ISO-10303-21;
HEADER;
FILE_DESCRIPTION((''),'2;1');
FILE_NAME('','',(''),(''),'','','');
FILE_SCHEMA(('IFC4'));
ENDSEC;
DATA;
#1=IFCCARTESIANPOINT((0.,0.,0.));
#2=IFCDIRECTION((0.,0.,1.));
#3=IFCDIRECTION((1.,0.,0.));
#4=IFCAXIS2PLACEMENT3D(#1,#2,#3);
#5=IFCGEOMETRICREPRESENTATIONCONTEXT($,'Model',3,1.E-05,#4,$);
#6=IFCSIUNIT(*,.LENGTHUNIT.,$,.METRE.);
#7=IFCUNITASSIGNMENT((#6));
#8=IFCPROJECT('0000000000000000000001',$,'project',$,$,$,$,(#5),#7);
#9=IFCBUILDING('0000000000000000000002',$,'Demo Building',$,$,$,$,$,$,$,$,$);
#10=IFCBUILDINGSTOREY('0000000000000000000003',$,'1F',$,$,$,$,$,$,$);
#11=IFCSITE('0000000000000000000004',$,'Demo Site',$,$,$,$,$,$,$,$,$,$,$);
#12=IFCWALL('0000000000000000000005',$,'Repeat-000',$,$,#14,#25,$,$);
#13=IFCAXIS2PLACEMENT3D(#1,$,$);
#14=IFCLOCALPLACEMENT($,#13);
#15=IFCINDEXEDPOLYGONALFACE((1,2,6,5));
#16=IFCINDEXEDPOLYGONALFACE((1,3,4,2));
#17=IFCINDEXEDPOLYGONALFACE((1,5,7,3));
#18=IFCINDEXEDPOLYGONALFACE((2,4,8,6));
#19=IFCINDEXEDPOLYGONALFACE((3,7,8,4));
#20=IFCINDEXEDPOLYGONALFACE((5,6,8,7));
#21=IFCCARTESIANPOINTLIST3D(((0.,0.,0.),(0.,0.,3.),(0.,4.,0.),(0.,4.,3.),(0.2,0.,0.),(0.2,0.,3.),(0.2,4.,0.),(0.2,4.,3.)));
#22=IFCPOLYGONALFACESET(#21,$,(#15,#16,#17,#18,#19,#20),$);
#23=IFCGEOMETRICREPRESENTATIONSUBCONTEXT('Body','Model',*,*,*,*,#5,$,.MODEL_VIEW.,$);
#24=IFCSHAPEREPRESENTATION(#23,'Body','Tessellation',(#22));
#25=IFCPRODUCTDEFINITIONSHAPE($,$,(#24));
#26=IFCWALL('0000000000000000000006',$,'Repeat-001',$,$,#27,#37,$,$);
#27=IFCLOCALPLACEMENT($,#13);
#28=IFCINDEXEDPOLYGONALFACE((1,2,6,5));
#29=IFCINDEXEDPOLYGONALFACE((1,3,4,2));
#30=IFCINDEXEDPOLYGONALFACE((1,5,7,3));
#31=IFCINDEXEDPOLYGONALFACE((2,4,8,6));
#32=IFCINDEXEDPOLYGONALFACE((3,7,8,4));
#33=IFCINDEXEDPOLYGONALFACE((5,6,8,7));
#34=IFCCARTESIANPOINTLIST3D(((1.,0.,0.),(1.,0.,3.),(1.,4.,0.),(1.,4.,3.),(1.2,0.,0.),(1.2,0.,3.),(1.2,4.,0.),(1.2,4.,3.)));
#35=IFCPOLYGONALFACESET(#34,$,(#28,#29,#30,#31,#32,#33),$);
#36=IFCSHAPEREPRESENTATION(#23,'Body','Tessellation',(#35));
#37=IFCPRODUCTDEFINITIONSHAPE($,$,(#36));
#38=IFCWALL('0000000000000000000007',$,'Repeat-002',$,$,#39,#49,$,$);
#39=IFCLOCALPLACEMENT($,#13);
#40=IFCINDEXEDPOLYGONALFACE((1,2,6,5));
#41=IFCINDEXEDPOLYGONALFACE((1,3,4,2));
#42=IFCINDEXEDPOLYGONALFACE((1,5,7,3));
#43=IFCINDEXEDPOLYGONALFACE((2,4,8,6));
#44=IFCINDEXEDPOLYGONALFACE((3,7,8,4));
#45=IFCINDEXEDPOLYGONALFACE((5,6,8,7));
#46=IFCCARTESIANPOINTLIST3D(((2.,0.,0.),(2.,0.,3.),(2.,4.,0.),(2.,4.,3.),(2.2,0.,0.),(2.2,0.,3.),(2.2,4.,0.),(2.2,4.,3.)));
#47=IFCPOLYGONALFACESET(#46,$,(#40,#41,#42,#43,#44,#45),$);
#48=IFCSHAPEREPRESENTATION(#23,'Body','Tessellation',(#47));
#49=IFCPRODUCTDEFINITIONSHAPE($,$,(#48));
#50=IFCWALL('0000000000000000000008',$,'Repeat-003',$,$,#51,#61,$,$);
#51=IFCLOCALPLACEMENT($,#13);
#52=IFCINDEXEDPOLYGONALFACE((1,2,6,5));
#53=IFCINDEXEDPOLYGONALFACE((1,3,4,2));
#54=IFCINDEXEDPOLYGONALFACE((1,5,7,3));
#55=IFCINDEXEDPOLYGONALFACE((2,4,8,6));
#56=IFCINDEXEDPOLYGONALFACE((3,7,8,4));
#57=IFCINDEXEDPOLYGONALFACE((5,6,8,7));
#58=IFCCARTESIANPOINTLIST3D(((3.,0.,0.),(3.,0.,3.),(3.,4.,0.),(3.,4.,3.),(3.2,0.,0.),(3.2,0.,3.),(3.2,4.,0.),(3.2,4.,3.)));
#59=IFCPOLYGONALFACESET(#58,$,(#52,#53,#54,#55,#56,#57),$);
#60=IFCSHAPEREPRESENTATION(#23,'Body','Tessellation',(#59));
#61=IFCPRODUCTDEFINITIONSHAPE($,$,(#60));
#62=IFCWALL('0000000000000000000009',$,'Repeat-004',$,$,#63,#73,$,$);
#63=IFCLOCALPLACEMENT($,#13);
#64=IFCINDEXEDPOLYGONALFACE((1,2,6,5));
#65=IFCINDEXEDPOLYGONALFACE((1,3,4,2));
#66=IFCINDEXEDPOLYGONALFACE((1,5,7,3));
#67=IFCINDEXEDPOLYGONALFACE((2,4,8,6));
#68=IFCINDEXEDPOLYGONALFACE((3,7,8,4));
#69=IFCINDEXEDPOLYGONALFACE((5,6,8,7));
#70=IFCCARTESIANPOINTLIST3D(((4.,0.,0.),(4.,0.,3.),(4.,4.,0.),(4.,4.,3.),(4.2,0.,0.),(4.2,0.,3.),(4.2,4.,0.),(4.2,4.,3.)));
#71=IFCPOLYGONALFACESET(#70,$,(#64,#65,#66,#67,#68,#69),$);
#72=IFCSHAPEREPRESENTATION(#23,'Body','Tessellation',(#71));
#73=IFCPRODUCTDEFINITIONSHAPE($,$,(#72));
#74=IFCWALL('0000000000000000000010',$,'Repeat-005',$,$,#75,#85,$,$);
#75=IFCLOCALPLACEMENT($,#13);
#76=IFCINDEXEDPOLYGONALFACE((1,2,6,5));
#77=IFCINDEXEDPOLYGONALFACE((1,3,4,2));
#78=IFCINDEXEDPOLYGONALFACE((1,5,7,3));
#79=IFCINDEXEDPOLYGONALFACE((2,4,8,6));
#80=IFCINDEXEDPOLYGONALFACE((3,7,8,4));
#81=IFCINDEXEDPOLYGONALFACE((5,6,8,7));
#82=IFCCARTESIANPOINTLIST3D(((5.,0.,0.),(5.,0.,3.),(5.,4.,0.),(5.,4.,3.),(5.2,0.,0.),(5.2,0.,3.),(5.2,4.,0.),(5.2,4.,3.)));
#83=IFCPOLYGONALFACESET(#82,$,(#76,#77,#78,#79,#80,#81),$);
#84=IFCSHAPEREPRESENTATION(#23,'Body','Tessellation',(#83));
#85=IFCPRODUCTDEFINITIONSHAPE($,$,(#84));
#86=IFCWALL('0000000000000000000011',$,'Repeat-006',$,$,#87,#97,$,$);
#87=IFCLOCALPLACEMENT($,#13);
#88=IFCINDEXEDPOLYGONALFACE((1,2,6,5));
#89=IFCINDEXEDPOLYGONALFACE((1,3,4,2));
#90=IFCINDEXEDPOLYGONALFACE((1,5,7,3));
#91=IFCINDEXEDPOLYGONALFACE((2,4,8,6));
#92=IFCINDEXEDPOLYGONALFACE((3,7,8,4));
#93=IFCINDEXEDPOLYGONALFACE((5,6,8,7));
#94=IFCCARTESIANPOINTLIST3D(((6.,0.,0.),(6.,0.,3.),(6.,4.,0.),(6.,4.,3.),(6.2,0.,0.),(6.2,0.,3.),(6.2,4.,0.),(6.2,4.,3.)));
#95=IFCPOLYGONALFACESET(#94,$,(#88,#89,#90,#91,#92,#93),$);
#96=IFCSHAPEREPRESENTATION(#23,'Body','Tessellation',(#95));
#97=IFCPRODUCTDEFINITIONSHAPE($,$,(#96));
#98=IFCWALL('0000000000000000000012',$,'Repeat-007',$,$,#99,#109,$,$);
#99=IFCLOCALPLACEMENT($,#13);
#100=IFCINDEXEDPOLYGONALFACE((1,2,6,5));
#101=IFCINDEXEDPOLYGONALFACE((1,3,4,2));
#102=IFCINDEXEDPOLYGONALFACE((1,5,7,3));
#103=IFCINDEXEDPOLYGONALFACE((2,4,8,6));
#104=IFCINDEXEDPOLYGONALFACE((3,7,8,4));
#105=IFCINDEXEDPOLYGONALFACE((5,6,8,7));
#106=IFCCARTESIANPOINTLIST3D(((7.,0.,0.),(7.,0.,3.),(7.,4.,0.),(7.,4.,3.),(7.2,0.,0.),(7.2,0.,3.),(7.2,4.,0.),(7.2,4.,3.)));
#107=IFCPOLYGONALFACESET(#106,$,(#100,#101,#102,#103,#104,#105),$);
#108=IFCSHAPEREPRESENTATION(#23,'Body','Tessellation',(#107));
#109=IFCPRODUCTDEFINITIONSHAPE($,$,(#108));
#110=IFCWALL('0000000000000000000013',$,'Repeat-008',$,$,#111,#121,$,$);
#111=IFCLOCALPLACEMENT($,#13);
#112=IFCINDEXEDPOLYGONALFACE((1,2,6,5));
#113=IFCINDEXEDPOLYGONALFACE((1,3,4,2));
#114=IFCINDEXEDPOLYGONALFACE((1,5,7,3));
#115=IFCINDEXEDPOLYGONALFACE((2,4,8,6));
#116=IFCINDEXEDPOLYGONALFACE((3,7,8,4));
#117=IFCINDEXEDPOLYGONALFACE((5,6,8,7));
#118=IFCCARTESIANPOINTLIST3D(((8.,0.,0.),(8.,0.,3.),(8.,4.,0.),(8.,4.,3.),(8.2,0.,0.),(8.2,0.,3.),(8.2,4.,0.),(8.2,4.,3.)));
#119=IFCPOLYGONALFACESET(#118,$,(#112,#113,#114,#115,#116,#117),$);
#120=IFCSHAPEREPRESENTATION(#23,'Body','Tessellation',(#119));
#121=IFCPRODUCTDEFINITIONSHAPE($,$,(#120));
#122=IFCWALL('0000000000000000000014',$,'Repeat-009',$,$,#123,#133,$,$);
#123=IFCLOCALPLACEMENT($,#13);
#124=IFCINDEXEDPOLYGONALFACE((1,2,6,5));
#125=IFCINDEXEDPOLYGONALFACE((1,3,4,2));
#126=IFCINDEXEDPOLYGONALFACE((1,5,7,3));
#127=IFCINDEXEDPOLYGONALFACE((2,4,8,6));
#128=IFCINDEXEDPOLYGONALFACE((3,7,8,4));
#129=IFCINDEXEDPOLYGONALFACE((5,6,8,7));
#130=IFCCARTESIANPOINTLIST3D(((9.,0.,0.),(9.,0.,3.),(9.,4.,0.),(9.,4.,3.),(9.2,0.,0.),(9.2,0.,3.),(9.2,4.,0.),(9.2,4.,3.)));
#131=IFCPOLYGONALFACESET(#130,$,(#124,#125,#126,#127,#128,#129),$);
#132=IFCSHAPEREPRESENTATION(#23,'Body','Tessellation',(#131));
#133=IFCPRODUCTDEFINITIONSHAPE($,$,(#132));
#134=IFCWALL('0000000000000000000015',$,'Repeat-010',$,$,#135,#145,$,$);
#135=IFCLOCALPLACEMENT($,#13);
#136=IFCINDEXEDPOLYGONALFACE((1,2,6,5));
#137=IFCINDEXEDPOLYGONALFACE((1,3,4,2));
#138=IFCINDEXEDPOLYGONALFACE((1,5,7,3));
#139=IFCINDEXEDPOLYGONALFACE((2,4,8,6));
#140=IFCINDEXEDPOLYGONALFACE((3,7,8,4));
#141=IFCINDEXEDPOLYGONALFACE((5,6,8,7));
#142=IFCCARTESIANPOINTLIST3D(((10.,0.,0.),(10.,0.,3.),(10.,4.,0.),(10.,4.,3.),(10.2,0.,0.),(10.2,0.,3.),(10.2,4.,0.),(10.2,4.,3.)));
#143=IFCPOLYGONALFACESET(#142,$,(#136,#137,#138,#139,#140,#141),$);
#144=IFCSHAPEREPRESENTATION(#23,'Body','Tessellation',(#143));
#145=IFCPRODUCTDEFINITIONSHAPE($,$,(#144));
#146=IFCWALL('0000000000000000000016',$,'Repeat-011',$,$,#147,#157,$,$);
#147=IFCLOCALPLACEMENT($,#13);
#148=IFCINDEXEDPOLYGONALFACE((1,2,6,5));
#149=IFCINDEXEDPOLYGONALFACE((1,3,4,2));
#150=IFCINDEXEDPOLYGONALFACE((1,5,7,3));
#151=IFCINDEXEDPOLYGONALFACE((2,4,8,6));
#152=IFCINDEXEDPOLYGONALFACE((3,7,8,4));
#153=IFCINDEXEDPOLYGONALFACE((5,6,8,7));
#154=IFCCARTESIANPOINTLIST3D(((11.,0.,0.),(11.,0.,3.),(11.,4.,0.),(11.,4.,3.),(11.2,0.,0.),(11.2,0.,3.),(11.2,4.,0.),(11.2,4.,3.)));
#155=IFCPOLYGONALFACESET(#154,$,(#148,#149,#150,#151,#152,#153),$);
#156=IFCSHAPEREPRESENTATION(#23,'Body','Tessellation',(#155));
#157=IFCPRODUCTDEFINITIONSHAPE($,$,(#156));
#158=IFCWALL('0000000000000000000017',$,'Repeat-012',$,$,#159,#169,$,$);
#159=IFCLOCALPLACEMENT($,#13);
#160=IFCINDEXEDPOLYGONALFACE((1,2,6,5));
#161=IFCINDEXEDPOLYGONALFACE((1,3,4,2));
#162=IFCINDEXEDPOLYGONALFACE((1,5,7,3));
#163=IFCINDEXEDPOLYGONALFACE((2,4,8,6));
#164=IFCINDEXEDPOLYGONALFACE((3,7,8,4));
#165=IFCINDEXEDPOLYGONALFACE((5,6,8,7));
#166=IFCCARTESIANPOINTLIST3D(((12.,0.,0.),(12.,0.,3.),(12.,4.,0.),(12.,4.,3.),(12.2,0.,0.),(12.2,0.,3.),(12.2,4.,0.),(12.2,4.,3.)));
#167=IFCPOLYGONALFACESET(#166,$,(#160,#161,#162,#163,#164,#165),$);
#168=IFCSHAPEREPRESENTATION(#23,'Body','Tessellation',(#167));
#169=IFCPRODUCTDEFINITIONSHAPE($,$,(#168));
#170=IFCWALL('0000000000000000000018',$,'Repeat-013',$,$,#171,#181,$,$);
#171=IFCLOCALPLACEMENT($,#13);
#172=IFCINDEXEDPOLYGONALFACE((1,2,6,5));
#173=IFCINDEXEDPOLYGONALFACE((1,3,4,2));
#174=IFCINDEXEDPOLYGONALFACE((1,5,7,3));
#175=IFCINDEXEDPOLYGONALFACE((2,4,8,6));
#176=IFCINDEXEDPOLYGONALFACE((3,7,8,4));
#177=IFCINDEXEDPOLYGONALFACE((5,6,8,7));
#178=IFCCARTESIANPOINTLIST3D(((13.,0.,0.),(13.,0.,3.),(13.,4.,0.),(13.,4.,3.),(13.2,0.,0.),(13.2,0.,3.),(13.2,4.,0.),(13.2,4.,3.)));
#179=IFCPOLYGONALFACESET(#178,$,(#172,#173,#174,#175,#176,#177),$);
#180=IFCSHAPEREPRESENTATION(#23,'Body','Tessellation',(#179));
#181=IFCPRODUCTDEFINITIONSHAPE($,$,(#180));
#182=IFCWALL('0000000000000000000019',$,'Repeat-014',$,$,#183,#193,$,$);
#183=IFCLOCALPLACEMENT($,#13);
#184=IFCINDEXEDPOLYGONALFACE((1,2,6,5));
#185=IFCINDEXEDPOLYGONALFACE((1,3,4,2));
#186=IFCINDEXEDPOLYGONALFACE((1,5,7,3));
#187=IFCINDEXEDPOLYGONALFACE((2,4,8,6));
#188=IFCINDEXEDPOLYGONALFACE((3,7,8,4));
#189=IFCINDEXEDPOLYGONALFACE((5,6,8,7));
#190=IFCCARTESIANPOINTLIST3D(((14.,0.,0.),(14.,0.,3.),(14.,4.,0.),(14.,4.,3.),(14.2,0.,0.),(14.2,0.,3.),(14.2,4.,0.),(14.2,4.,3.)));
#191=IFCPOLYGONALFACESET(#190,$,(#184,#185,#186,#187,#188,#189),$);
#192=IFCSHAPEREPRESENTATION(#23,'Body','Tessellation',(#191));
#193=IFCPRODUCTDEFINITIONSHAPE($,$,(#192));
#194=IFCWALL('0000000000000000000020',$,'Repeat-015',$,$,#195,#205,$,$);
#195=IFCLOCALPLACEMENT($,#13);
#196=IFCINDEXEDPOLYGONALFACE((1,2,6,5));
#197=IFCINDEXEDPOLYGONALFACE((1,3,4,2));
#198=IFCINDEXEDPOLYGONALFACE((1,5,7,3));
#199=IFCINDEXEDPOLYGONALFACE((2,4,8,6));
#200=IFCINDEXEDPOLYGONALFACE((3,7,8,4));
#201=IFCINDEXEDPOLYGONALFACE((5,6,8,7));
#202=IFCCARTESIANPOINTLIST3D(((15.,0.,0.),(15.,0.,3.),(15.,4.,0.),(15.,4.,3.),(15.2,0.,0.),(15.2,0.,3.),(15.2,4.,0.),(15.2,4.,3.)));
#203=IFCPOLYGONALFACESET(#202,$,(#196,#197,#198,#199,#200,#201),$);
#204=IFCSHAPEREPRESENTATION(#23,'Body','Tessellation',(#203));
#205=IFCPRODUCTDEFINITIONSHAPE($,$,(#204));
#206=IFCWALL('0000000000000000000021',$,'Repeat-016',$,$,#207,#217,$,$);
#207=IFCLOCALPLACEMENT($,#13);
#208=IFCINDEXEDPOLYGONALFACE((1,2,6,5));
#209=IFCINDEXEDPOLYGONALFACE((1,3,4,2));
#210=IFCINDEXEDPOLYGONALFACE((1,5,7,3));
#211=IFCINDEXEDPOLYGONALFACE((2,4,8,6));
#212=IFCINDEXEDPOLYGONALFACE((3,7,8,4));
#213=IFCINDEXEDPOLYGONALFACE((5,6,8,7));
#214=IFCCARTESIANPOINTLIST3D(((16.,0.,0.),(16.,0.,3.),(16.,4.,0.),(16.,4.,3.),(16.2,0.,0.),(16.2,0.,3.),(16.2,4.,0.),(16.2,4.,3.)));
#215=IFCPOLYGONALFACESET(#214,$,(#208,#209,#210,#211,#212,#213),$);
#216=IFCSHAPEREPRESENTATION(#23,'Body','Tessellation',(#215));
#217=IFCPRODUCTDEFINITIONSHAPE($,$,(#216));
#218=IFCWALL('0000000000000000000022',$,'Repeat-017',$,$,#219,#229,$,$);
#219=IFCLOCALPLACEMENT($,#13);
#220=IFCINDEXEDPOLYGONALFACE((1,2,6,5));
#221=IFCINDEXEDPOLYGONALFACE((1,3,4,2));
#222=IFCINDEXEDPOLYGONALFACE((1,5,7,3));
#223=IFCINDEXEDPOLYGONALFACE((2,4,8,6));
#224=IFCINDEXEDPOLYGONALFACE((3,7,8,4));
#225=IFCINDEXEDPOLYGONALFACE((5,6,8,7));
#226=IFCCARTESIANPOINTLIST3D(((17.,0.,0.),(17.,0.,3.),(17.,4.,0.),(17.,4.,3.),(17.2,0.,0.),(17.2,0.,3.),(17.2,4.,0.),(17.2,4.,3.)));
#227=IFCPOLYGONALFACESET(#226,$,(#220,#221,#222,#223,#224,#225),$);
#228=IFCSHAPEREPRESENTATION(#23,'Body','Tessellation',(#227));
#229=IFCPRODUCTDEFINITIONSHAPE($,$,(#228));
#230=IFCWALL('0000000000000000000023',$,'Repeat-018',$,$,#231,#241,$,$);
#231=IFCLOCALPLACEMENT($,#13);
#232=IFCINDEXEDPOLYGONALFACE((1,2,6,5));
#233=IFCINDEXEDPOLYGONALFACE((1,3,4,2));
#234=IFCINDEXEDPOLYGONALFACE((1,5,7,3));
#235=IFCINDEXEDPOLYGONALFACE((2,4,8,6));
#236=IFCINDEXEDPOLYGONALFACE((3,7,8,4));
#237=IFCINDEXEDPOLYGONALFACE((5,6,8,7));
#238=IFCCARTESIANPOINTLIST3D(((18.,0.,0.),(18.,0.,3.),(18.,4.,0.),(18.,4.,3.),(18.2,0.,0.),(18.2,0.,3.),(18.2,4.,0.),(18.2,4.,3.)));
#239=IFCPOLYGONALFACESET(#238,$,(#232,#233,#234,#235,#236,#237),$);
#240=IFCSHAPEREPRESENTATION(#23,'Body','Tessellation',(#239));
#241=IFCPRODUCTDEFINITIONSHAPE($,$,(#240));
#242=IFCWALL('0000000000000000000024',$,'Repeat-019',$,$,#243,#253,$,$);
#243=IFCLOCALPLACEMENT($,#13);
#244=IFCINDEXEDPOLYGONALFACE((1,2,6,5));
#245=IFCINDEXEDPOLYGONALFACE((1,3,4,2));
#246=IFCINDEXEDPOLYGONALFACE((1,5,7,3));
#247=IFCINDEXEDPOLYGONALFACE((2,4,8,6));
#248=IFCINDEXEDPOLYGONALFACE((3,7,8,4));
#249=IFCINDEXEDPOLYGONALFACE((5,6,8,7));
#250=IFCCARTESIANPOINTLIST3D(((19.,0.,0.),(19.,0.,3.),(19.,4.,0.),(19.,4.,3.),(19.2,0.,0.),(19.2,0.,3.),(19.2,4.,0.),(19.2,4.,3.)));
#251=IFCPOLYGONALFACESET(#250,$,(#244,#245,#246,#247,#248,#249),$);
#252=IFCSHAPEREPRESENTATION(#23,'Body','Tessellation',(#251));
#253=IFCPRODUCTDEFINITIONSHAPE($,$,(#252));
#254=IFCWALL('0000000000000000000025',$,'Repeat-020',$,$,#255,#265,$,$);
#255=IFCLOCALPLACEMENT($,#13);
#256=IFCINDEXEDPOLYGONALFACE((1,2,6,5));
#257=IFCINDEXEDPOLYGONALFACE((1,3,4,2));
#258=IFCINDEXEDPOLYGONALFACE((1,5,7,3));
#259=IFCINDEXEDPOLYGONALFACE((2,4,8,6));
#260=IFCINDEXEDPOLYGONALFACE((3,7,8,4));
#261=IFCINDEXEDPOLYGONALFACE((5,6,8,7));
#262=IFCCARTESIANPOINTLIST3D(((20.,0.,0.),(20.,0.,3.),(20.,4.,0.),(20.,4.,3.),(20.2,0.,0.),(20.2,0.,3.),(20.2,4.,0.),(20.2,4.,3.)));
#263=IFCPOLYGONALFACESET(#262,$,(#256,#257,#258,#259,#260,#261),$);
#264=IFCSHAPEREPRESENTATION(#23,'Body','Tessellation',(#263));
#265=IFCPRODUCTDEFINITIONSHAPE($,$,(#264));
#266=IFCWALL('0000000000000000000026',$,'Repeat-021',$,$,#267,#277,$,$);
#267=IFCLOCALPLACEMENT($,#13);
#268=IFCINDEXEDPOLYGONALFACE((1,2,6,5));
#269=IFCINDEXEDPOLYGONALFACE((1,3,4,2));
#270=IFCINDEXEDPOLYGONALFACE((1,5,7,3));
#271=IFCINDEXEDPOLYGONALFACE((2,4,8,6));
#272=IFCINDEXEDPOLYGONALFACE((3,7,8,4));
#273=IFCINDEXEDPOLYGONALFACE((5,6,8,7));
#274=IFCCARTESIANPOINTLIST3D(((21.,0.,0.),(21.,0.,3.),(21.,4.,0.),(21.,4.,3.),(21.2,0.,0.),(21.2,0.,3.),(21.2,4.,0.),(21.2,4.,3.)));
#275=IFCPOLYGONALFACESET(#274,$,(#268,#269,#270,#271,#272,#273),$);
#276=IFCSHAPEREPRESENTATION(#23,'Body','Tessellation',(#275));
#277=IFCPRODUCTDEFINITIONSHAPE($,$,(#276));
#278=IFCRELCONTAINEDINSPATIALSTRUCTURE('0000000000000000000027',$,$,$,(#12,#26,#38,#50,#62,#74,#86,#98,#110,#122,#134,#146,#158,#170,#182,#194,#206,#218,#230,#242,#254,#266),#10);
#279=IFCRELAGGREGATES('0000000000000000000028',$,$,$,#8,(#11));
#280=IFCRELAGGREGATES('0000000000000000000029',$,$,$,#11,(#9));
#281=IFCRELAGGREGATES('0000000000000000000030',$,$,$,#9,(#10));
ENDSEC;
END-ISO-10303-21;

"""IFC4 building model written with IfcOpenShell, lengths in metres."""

from ifc_helpers import new_model, entity, si_unit, frame, origin_with_axes, place, context, subcontext, project, spatial, element, save


model = new_model("IFC4")

# Units and contexts
model_context = context("Model", 3, precision=1e-05, world=origin_with_axes())
body_context = subcontext(model_context, "Body", "Model", "MODEL_VIEW")
ifc_project = project(units=[si_unit("LENGTHUNIT", "METRE")], contexts=[model_context])

# Site, building, storey
site = spatial("IfcSite", under=ifc_project, Name="Demo Site")
building = spatial("IfcBuilding", under=site, Name="Demo Building")
storey = spatial("IfcBuildingStorey", under=building, Name="1F")

# Walls
for number, where, z_axis, x_axis, name in (
    (1, (0.0, 0.0, 0.0), (0.0, 0.0, 1.0), (1.0, 0.0, 0.0), "Repeat-000"),
    (2, (1.0, 0.0, 0.0), (0.0, 0.0, 1.0), (1.0, 0.0, 0.0), "Repeat-001"),
    (3, (2.0, 0.0, 0.0), (0.0, 0.0, 1.0), (1.0, 0.0, 0.0), "Repeat-002"),
    (4, (3.0, 0.0, 0.0), (0.0, 0.0, 1.0), (1.0, 0.0, 0.0), "Repeat-003"),
    (5, (4.0, 0.0, 0.0), (0.0, 0.0, 1.0), (1.0, 0.0, 0.0), "Repeat-004"),
    (6, (5.0, 0.0, 0.0), (0.0, 0.0, 1.0), (1.0, 0.0, 0.0), "Repeat-005"),
    (7, (6.0, 0.0, 0.0), (0.0, 0.0, 1.0), (1.0, 0.0, 0.0), "Repeat-006"),
    (8, (7.0, 0.0, 0.0), (0.0, 0.0, 1.0), (1.0, 0.0, 0.0), "Repeat-007"),
    (9, (8.0, 0.0, 0.0), (0.0, 0.0, 1.0), (1.0, 0.0, 0.0), "Repeat-008"),
    (10, (9.0, 0.0, 0.0), (0.0, 0.0, 1.0), (1.0, 0.0, 0.0), "Repeat-009"),
    (11, (10.0, 0.0, 0.0), (0.0, 0.0, 1.0), (1.0, 0.0, 0.0), "Repeat-010"),
    (12, (11.0, 0.0, 0.0), (0.0, 0.0, 1.0), (1.0, 0.0, 0.0), "Repeat-011"),
    (13, (12.0, 0.0, 0.0), (0.0, 0.0, 1.0), (1.0, 0.0, 0.0), "Repeat-012"),
    (14, (13.0, 0.0, 0.0), (0.0, 0.0, 1.0), (1.0, 0.0, 0.0), "Repeat-013"),
    (15, (14.0, 0.0, 0.0), (0.0, 0.0, 1.0), (1.0, 0.0, 0.0), "Repeat-014"),
    (16, (15.0, 0.0, 0.0), (0.0, 0.0, 1.0), (1.0, 0.0, 0.0), "Repeat-015"),
    (17, (16.0, 0.0, 0.0), (0.0, 0.0, 1.0), (1.0, 0.0, 0.0), "Repeat-016"),
    (18, (17.0, 0.0, 0.0), (0.0, 0.0, 1.0), (1.0, 0.0, 0.0), "Repeat-017"),
    (19, (18.0, 0.0, 0.0), (0.0, 0.0, 1.0), (1.0, 0.0, 0.0), "Repeat-018"),
    (20, (19.0, 0.0, 0.0), (0.0, 0.0, 1.0), (1.0, 0.0, 0.0), "Repeat-019"),
    (21, (20.0, 0.0, 0.0), (0.0, 0.0, 1.0), (1.0, 0.0, 0.0), "Repeat-020"),
    (22, (21.0, 0.0, 0.0), (0.0, 0.0, 1.0), (1.0, 0.0, 0.0), "Repeat-021"),
):
    element("IfcWall", number, at=place(None, frame(where, z_axis=z_axis, x_axis=x_axis)), inside=storey, Name=name, context=body_context, shape_type="CSG", body=[
        entity("IfcBlock", entity("IfcAxis2Placement3D", entity("IfcCartesianPoint", [0.0, 0.0, 0.0]), entity("IfcDirection", [0.0, 0.0, 1.0]), entity("IfcDirection", [1.0, 0.0, 0.0])), 0.2, 4.0, 3.0),
    ])

save(model, "model.ifc")
